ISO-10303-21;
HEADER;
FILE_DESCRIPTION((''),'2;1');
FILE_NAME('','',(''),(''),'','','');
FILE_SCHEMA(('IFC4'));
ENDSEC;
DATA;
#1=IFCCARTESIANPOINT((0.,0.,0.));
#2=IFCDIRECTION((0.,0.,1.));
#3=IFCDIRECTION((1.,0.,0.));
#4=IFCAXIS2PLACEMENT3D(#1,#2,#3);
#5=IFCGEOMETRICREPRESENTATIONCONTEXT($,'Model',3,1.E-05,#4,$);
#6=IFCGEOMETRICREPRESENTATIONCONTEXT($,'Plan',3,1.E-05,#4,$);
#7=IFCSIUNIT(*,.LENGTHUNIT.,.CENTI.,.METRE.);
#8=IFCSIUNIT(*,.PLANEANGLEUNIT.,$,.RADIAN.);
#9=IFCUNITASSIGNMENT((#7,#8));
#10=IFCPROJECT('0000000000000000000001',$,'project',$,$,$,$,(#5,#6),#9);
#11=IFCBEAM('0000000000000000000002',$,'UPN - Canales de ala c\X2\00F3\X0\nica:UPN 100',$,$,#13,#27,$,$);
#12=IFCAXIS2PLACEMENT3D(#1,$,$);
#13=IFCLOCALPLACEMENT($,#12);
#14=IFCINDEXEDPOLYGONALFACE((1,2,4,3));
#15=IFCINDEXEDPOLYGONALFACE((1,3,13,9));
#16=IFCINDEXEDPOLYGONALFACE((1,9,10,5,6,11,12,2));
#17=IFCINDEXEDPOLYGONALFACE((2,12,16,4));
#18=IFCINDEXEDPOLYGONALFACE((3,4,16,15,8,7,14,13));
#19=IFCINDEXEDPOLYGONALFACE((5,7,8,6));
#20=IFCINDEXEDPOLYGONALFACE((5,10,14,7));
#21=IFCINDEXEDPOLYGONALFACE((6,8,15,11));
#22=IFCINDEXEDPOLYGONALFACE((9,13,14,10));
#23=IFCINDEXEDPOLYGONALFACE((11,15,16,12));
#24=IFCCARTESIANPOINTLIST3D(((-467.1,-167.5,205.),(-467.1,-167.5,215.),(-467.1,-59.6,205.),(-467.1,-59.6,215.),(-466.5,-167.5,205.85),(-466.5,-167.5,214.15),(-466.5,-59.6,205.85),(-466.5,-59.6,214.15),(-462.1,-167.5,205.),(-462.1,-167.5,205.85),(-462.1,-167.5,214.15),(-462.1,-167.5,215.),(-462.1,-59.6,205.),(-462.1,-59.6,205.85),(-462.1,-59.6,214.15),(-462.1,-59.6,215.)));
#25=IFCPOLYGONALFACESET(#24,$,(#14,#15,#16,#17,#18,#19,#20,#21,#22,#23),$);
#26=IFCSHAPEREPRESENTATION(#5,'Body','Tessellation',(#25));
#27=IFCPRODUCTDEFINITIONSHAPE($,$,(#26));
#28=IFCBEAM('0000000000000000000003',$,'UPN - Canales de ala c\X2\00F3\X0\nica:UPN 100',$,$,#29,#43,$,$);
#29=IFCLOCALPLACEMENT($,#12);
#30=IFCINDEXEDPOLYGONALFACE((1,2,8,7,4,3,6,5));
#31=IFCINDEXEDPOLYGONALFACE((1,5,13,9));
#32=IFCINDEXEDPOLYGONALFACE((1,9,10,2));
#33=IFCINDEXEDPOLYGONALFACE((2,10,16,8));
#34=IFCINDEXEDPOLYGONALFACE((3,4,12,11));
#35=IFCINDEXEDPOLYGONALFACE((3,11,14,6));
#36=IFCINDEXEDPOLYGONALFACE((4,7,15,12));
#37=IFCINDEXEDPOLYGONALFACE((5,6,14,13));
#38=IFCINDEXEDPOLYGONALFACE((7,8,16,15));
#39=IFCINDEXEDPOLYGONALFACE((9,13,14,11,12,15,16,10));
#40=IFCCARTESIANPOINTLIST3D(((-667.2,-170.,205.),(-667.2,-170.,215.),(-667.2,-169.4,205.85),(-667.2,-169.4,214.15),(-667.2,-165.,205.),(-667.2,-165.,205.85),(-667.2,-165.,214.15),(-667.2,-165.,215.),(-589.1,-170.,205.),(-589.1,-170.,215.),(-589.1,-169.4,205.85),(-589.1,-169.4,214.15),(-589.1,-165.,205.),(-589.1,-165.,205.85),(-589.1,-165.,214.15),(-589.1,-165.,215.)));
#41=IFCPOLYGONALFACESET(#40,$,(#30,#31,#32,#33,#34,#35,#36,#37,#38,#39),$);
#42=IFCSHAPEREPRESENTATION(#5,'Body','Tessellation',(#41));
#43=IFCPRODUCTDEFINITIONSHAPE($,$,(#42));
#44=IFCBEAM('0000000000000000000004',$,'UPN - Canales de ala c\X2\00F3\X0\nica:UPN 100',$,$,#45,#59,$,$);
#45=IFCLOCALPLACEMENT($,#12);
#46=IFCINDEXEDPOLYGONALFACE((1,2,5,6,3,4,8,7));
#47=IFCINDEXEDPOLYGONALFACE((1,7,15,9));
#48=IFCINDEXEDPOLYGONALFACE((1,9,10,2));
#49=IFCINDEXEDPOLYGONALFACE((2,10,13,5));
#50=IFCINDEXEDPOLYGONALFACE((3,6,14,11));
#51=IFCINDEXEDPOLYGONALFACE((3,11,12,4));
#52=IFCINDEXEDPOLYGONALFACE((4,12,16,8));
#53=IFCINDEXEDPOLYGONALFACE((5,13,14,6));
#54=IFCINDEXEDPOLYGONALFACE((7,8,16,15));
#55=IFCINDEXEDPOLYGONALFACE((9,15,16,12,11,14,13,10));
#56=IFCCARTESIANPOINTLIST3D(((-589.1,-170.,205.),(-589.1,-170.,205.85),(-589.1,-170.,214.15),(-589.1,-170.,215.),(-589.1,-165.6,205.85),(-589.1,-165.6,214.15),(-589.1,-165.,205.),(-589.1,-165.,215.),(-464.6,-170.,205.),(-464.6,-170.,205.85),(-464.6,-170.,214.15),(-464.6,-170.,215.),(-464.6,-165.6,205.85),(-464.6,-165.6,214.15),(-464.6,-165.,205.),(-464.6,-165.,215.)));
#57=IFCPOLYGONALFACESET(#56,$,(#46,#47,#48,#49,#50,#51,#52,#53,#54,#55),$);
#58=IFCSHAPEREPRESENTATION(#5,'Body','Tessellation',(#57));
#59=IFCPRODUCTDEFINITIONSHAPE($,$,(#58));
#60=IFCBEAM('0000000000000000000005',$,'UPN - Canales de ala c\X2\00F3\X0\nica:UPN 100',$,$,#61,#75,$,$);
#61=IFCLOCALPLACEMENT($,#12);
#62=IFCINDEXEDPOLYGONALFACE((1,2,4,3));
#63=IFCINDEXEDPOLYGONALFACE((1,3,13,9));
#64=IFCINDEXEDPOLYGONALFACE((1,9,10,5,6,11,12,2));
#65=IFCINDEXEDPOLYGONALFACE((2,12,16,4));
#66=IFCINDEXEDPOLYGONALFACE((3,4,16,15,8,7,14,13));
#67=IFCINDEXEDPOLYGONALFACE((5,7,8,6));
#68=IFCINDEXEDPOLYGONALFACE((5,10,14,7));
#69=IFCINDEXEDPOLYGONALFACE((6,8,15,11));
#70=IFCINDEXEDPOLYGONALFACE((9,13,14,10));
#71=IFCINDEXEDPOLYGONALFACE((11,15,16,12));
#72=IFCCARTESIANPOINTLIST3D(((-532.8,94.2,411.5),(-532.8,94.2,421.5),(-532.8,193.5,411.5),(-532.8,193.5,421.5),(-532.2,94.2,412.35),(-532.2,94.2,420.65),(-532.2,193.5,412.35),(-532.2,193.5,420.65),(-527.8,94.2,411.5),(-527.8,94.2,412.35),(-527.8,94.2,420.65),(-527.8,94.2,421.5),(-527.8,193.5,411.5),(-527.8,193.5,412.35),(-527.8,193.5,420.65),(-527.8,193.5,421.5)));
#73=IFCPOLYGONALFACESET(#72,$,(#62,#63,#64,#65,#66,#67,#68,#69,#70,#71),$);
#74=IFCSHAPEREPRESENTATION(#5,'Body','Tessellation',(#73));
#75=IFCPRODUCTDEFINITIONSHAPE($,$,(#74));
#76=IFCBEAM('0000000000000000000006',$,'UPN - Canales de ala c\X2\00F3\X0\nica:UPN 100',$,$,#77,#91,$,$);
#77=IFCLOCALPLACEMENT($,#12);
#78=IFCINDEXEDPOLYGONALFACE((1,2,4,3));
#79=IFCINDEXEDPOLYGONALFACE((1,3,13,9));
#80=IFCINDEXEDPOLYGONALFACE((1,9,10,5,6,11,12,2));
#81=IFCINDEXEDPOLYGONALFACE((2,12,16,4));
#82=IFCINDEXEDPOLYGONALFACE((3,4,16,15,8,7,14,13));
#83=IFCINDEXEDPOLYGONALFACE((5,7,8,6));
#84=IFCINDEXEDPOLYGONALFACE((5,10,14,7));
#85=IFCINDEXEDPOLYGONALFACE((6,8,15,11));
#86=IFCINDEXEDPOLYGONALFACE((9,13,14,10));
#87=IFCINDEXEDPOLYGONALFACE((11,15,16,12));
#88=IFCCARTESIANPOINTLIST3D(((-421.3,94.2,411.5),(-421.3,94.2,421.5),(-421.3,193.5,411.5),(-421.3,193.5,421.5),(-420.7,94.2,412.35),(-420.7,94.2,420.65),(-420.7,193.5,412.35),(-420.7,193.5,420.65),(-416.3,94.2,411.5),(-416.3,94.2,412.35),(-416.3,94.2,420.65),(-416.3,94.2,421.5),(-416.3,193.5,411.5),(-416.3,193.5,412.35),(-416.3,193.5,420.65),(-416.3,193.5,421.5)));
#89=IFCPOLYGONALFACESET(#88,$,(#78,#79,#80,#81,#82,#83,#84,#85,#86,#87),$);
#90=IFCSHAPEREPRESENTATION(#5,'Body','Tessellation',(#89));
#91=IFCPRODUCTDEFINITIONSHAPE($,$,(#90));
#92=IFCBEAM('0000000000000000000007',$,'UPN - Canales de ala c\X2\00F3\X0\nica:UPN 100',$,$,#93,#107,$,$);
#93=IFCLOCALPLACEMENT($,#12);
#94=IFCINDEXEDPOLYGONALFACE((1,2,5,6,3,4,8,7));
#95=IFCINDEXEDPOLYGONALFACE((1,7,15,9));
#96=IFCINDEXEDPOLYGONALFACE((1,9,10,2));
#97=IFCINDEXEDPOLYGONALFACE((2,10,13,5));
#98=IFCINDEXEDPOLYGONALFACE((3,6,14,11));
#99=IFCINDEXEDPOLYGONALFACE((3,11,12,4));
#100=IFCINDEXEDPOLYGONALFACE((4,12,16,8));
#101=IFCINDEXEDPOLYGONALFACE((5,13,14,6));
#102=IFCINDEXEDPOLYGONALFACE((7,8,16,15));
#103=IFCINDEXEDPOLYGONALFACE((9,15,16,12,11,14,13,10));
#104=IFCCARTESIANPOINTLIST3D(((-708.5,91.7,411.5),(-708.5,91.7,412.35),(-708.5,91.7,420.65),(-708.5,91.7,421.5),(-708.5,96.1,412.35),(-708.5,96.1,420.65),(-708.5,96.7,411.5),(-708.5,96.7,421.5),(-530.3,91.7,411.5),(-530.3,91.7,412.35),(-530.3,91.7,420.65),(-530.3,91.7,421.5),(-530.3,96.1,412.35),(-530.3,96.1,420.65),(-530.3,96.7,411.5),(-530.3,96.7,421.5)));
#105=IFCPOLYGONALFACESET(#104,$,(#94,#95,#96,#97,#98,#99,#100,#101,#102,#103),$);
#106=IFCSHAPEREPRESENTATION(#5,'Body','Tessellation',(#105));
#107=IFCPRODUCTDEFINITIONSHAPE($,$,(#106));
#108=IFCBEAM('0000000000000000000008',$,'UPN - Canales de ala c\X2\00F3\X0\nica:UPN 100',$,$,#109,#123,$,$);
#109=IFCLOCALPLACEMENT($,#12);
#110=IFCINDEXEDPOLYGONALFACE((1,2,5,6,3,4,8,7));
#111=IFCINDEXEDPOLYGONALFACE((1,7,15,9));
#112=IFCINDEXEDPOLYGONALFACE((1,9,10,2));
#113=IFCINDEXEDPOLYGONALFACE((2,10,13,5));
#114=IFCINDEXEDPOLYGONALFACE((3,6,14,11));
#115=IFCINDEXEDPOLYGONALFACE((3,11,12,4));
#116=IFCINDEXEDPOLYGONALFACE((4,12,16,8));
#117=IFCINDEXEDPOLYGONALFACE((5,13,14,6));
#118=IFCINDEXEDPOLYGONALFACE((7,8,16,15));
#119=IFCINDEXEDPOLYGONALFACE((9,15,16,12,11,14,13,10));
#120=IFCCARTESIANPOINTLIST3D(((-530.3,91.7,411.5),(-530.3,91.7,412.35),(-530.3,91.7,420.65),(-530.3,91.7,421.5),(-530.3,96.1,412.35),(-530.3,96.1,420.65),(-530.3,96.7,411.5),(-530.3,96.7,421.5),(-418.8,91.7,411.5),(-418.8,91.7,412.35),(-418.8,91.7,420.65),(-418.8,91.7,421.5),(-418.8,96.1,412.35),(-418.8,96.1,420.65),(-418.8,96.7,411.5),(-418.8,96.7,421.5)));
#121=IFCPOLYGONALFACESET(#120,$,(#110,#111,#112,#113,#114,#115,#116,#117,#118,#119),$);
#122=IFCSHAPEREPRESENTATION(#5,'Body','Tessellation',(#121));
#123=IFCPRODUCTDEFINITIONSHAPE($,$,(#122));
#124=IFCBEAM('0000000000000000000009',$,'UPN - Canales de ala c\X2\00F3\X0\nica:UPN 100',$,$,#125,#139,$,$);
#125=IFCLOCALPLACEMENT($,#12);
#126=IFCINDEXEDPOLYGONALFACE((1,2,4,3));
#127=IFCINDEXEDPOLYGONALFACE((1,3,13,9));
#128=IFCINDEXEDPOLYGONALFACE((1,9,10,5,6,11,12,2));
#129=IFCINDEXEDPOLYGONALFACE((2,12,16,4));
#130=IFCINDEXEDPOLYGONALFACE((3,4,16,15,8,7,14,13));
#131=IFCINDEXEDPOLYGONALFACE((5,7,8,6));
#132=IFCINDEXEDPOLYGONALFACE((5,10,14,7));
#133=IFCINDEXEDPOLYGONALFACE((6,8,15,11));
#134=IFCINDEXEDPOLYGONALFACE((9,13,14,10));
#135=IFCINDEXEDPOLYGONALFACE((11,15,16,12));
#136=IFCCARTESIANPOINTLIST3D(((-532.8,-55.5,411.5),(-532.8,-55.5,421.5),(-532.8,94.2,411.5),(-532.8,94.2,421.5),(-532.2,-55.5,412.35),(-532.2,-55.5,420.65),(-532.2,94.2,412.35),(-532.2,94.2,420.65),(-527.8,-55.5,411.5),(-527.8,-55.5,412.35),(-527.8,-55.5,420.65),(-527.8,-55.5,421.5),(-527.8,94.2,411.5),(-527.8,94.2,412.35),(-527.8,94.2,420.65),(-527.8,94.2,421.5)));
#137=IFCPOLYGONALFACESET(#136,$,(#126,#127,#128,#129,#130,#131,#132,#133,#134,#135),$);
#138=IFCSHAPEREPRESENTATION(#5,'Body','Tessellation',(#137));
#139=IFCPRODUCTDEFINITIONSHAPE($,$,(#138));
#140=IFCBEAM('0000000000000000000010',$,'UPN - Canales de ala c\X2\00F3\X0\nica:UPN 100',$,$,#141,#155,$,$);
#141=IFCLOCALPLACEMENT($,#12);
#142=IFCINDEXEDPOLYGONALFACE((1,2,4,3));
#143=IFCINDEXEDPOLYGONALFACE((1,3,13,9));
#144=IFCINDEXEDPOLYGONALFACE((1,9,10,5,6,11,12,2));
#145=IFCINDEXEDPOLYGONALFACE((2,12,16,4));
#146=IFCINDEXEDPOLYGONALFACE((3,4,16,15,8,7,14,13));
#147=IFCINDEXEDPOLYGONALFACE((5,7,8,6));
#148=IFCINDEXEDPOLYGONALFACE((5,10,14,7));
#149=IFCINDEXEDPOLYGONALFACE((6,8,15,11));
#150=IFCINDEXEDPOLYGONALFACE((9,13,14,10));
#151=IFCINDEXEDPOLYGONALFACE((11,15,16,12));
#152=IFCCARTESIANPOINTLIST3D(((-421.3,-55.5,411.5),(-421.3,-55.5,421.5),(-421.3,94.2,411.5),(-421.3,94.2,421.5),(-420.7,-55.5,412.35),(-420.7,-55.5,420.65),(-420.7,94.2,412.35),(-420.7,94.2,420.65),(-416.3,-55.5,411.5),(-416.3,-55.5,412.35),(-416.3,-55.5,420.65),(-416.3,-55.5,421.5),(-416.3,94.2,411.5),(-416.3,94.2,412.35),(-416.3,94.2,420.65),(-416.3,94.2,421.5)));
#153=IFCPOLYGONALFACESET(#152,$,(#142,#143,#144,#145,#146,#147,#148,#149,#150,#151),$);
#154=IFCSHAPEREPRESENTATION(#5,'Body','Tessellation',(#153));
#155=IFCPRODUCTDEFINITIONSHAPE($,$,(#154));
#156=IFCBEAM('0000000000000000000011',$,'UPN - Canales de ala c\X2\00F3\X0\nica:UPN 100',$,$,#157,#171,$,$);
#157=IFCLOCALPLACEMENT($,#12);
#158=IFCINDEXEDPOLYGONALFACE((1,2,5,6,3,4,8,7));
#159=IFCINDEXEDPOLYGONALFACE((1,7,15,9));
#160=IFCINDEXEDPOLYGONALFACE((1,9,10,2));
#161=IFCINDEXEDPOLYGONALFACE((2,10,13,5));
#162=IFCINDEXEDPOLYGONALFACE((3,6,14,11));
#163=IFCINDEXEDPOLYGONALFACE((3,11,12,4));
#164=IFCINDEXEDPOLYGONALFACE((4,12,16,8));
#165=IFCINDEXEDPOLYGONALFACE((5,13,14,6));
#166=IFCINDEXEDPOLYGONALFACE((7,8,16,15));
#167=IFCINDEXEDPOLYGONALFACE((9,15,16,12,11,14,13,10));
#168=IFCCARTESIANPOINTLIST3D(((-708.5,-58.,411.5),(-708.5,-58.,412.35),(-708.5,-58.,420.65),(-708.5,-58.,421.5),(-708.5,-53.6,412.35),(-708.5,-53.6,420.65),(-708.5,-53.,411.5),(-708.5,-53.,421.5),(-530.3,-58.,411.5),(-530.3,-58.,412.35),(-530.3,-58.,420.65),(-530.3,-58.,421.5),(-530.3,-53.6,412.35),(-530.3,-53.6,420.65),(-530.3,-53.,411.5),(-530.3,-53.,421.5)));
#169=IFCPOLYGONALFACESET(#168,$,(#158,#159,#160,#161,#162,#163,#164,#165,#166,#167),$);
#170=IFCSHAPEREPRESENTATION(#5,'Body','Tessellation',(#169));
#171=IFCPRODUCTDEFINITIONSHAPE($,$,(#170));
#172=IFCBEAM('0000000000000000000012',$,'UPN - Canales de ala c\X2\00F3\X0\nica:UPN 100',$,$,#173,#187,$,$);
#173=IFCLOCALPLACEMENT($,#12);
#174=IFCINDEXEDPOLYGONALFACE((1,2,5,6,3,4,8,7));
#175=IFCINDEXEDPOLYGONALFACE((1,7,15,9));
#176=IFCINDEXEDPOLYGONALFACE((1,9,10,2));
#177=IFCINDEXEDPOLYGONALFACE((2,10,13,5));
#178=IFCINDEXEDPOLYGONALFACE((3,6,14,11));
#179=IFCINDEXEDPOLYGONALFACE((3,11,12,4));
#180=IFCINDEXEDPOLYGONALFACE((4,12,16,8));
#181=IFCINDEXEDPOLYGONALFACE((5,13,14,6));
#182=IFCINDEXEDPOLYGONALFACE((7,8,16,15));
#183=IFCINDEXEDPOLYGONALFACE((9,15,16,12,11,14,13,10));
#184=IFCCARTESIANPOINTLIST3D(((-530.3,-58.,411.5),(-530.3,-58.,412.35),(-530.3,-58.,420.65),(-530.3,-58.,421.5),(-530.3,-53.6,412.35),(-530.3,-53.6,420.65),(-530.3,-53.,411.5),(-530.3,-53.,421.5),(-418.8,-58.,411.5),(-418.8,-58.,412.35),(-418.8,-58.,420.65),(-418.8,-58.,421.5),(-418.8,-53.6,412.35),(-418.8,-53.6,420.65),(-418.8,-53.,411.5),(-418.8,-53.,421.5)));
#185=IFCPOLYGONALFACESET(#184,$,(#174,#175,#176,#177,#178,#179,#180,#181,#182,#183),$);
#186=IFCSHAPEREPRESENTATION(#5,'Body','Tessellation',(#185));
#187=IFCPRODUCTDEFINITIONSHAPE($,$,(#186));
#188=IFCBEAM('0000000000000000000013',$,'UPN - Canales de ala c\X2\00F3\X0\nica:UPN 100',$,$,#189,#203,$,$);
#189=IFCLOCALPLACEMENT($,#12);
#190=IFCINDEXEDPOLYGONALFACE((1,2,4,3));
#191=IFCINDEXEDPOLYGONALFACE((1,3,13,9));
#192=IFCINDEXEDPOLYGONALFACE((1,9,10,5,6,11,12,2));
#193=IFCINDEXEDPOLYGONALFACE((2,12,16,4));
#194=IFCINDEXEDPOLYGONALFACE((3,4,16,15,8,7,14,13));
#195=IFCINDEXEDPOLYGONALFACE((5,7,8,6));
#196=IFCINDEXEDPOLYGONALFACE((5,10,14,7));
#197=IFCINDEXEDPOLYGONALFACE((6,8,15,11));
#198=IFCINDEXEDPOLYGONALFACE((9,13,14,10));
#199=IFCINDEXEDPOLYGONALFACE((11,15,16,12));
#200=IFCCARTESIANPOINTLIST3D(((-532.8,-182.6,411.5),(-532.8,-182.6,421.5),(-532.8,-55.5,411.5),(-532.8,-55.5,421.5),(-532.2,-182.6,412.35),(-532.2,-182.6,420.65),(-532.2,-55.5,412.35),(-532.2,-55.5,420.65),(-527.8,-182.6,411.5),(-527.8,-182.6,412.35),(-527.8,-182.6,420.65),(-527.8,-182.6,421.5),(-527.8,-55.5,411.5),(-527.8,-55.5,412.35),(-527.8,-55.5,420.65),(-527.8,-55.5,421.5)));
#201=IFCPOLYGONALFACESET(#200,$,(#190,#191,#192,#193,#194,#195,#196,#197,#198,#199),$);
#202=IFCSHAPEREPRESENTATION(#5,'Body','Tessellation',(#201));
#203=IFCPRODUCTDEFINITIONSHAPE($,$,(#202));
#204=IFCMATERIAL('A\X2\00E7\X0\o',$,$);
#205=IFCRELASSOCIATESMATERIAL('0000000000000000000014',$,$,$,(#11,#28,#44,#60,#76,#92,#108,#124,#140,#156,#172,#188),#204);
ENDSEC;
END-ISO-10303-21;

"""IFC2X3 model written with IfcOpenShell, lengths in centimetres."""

from ifc_helpers import new_model, si_unit, frame, origin_with_axes, origin_2d_with_axis, place, context, project, u_section, extrude, material, element, save


model = new_model("IFC2X3")

# Units and contexts
model_context = context("Model", 3, precision=1e-05, world=origin_with_axes())
plan_context = context("Plan", 3, precision=1e-05, world=origin_with_axes())
ifc_project = project(units=[si_unit("LENGTHUNIT", "METRE", prefix="CENTI"), si_unit("PLANEANGLEUNIT", "RADIAN")], contexts=[model_context, plan_context])

# Shared definitions
ifc_material = material(Name="Aço")

# Beams
beam_1_placement = place(None, frame((-464.6, -167.5, 210.0), z_axis=(0.0, 1.0, 0.0), x_axis=(1.0, 0.0, 0.0)))
element("IfcBeam", 1, at=beam_1_placement, material=ifc_material, Name="UPN - Canales de ala cónica:UPN 100", context=model_context, shape_type="SweptSolid", body=[
    extrude(u_section(Depth=10.0, FlangeWidth=5.0, WebThickness=0.6, FlangeThickness=0.85, FilletRadius=0.0, EdgeRadius=0.0, FlangeSlope=0.0, CentreOfGravityInX=0.0, at=origin_2d_with_axis()), origin_with_axes(), (0.0, 0.0, 1.0), 107.9),
])
beam_2_placement = place(None, frame((-589.1, -167.5, 210.0), z_axis=(-1.0, 0.0, 0.0), x_axis=(0.0, 1.0, 0.0)))
element("IfcBeam", 2, at=beam_2_placement, material=ifc_material, Name="UPN - Canales de ala cónica:UPN 100", context=model_context, shape_type="SweptSolid", body=[
    extrude(u_section(Depth=10.0, FlangeWidth=5.0, WebThickness=0.6, FlangeThickness=0.85, FilletRadius=0.0, EdgeRadius=0.0, FlangeSlope=0.0, CentreOfGravityInX=0.0, at=origin_2d_with_axis()), origin_with_axes(), (0.0, 0.0, 1.0), 78.1),
])
beam_3_placement = place(None, frame((-464.6, -167.5, 210.0), z_axis=(-1.0, 0.0, 0.0), x_axis=(0.0, -1.0, 0.0)))
element("IfcBeam", 3, at=beam_3_placement, material=ifc_material, Name="UPN - Canales de ala cónica:UPN 100", context=model_context, shape_type="SweptSolid", body=[
    extrude(u_section(Depth=10.0, FlangeWidth=5.0, WebThickness=0.6, FlangeThickness=0.85, FilletRadius=0.0, EdgeRadius=0.0, FlangeSlope=0.0, CentreOfGravityInX=0.0, at=origin_2d_with_axis()), origin_with_axes(), (0.0, 0.0, 1.0), 124.5),
])
for number, where, z_axis, x_axis, name in (
    (4, (-530.3, 94.2, 416.5), (0.0, 1.0, 0.0), (1.0, 0.0, 0.0), "UPN - Canales de ala cónica:UPN 100"),
    (5, (-418.8, 94.2, 416.5), (0.0, 1.0, 0.0), (1.0, 0.0, 0.0), "UPN - Canales de ala cónica:UPN 100"),
):
    element("IfcBeam", number, at=place(None, frame(where, z_axis=z_axis, x_axis=x_axis)), material=ifc_material, Name=name, context=model_context, shape_type="SweptSolid", body=[
        extrude(u_section(Depth=10.0, FlangeWidth=5.0, WebThickness=0.6, FlangeThickness=0.85, FilletRadius=0.0, EdgeRadius=0.0, FlangeSlope=0.0, CentreOfGravityInX=0.0, at=origin_2d_with_axis()), origin_with_axes(), (0.0, 0.0, 1.0), 99.3),
    ])
beam_4_placement = place(None, frame((-530.3, 94.2, 416.5), z_axis=(-1.0, 0.0, 0.0), x_axis=(0.0, -1.0, 0.0)))
element("IfcBeam", 6, at=beam_4_placement, material=ifc_material, Name="UPN - Canales de ala cónica:UPN 100", context=model_context, shape_type="SweptSolid", body=[
    extrude(u_section(Depth=10.0, FlangeWidth=5.0, WebThickness=0.6, FlangeThickness=0.85, FilletRadius=0.0, EdgeRadius=0.0, FlangeSlope=0.0, CentreOfGravityInX=0.0, at=origin_2d_with_axis()), origin_with_axes(), (0.0, 0.0, 1.0), 178.2),
])
beam_5_placement = place(None, frame((-418.8, 94.2, 416.5), z_axis=(-1.0, 0.0, 0.0), x_axis=(0.0, -1.0, 0.0)))
element("IfcBeam", 7, at=beam_5_placement, material=ifc_material, Name="UPN - Canales de ala cónica:UPN 100", context=model_context, shape_type="SweptSolid", body=[
    extrude(u_section(Depth=10.0, FlangeWidth=5.0, WebThickness=0.6, FlangeThickness=0.85, FilletRadius=0.0, EdgeRadius=0.0, FlangeSlope=0.0, CentreOfGravityInX=0.0, at=origin_2d_with_axis()), origin_with_axes(), (0.0, 0.0, 1.0), 111.5),
])
for number, where, z_axis, x_axis, name in (
    (8, (-530.3, -55.5, 416.5), (0.0, 1.0, 0.0), (1.0, 0.0, 0.0), "UPN - Canales de ala cónica:UPN 100"),
    (9, (-418.8, -55.5, 416.5), (0.0, 1.0, 0.0), (1.0, 0.0, 0.0), "UPN - Canales de ala cónica:UPN 100"),
):
    element("IfcBeam", number, at=place(None, frame(where, z_axis=z_axis, x_axis=x_axis)), material=ifc_material, Name=name, context=model_context, shape_type="SweptSolid", body=[
        extrude(u_section(Depth=10.0, FlangeWidth=5.0, WebThickness=0.6, FlangeThickness=0.85, FilletRadius=0.0, EdgeRadius=0.0, FlangeSlope=0.0, CentreOfGravityInX=0.0, at=origin_2d_with_axis()), origin_with_axes(), (0.0, 0.0, 1.0), 149.7),
    ])
beam_6_placement = place(None, frame((-530.3, -55.5, 416.5), z_axis=(-1.0, 0.0, 0.0), x_axis=(0.0, -1.0, 0.0)))
element("IfcBeam", 10, at=beam_6_placement, material=ifc_material, Name="UPN - Canales de ala cónica:UPN 100", context=model_context, shape_type="SweptSolid", body=[
    extrude(u_section(Depth=10.0, FlangeWidth=5.0, WebThickness=0.6, FlangeThickness=0.85, FilletRadius=0.0, EdgeRadius=0.0, FlangeSlope=0.0, CentreOfGravityInX=0.0, at=origin_2d_with_axis()), origin_with_axes(), (0.0, 0.0, 1.0), 178.2),
])
beam_7_placement = place(None, frame((-418.8, -55.5, 416.5), z_axis=(-1.0, 0.0, 0.0), x_axis=(0.0, -1.0, 0.0)))
element("IfcBeam", 11, at=beam_7_placement, material=ifc_material, Name="UPN - Canales de ala cónica:UPN 100", context=model_context, shape_type="SweptSolid", body=[
    extrude(u_section(Depth=10.0, FlangeWidth=5.0, WebThickness=0.6, FlangeThickness=0.85, FilletRadius=0.0, EdgeRadius=0.0, FlangeSlope=0.0, CentreOfGravityInX=0.0, at=origin_2d_with_axis()), origin_with_axes(), (0.0, 0.0, 1.0), 111.5),
])
for number, where, z_axis, x_axis, name in (
    (12, (-530.3, -182.6, 416.5), (0.0, 1.0, 0.0), (1.0, 0.0, 0.0), "UPN - Canales de ala cónica:UPN 100"),
):
    element("IfcBeam", number, at=place(None, frame(where, z_axis=z_axis, x_axis=x_axis)), material=ifc_material, Name=name, context=model_context, shape_type="SweptSolid", body=[
        extrude(u_section(Depth=10.0, FlangeWidth=5.0, WebThickness=0.6, FlangeThickness=0.85, FilletRadius=0.0, EdgeRadius=0.0, FlangeSlope=0.0, CentreOfGravityInX=0.0, at=origin_2d_with_axis()), origin_with_axes(), (0.0, 0.0, 1.0), 127.1),
    ])

save(model, "model.ifc")
